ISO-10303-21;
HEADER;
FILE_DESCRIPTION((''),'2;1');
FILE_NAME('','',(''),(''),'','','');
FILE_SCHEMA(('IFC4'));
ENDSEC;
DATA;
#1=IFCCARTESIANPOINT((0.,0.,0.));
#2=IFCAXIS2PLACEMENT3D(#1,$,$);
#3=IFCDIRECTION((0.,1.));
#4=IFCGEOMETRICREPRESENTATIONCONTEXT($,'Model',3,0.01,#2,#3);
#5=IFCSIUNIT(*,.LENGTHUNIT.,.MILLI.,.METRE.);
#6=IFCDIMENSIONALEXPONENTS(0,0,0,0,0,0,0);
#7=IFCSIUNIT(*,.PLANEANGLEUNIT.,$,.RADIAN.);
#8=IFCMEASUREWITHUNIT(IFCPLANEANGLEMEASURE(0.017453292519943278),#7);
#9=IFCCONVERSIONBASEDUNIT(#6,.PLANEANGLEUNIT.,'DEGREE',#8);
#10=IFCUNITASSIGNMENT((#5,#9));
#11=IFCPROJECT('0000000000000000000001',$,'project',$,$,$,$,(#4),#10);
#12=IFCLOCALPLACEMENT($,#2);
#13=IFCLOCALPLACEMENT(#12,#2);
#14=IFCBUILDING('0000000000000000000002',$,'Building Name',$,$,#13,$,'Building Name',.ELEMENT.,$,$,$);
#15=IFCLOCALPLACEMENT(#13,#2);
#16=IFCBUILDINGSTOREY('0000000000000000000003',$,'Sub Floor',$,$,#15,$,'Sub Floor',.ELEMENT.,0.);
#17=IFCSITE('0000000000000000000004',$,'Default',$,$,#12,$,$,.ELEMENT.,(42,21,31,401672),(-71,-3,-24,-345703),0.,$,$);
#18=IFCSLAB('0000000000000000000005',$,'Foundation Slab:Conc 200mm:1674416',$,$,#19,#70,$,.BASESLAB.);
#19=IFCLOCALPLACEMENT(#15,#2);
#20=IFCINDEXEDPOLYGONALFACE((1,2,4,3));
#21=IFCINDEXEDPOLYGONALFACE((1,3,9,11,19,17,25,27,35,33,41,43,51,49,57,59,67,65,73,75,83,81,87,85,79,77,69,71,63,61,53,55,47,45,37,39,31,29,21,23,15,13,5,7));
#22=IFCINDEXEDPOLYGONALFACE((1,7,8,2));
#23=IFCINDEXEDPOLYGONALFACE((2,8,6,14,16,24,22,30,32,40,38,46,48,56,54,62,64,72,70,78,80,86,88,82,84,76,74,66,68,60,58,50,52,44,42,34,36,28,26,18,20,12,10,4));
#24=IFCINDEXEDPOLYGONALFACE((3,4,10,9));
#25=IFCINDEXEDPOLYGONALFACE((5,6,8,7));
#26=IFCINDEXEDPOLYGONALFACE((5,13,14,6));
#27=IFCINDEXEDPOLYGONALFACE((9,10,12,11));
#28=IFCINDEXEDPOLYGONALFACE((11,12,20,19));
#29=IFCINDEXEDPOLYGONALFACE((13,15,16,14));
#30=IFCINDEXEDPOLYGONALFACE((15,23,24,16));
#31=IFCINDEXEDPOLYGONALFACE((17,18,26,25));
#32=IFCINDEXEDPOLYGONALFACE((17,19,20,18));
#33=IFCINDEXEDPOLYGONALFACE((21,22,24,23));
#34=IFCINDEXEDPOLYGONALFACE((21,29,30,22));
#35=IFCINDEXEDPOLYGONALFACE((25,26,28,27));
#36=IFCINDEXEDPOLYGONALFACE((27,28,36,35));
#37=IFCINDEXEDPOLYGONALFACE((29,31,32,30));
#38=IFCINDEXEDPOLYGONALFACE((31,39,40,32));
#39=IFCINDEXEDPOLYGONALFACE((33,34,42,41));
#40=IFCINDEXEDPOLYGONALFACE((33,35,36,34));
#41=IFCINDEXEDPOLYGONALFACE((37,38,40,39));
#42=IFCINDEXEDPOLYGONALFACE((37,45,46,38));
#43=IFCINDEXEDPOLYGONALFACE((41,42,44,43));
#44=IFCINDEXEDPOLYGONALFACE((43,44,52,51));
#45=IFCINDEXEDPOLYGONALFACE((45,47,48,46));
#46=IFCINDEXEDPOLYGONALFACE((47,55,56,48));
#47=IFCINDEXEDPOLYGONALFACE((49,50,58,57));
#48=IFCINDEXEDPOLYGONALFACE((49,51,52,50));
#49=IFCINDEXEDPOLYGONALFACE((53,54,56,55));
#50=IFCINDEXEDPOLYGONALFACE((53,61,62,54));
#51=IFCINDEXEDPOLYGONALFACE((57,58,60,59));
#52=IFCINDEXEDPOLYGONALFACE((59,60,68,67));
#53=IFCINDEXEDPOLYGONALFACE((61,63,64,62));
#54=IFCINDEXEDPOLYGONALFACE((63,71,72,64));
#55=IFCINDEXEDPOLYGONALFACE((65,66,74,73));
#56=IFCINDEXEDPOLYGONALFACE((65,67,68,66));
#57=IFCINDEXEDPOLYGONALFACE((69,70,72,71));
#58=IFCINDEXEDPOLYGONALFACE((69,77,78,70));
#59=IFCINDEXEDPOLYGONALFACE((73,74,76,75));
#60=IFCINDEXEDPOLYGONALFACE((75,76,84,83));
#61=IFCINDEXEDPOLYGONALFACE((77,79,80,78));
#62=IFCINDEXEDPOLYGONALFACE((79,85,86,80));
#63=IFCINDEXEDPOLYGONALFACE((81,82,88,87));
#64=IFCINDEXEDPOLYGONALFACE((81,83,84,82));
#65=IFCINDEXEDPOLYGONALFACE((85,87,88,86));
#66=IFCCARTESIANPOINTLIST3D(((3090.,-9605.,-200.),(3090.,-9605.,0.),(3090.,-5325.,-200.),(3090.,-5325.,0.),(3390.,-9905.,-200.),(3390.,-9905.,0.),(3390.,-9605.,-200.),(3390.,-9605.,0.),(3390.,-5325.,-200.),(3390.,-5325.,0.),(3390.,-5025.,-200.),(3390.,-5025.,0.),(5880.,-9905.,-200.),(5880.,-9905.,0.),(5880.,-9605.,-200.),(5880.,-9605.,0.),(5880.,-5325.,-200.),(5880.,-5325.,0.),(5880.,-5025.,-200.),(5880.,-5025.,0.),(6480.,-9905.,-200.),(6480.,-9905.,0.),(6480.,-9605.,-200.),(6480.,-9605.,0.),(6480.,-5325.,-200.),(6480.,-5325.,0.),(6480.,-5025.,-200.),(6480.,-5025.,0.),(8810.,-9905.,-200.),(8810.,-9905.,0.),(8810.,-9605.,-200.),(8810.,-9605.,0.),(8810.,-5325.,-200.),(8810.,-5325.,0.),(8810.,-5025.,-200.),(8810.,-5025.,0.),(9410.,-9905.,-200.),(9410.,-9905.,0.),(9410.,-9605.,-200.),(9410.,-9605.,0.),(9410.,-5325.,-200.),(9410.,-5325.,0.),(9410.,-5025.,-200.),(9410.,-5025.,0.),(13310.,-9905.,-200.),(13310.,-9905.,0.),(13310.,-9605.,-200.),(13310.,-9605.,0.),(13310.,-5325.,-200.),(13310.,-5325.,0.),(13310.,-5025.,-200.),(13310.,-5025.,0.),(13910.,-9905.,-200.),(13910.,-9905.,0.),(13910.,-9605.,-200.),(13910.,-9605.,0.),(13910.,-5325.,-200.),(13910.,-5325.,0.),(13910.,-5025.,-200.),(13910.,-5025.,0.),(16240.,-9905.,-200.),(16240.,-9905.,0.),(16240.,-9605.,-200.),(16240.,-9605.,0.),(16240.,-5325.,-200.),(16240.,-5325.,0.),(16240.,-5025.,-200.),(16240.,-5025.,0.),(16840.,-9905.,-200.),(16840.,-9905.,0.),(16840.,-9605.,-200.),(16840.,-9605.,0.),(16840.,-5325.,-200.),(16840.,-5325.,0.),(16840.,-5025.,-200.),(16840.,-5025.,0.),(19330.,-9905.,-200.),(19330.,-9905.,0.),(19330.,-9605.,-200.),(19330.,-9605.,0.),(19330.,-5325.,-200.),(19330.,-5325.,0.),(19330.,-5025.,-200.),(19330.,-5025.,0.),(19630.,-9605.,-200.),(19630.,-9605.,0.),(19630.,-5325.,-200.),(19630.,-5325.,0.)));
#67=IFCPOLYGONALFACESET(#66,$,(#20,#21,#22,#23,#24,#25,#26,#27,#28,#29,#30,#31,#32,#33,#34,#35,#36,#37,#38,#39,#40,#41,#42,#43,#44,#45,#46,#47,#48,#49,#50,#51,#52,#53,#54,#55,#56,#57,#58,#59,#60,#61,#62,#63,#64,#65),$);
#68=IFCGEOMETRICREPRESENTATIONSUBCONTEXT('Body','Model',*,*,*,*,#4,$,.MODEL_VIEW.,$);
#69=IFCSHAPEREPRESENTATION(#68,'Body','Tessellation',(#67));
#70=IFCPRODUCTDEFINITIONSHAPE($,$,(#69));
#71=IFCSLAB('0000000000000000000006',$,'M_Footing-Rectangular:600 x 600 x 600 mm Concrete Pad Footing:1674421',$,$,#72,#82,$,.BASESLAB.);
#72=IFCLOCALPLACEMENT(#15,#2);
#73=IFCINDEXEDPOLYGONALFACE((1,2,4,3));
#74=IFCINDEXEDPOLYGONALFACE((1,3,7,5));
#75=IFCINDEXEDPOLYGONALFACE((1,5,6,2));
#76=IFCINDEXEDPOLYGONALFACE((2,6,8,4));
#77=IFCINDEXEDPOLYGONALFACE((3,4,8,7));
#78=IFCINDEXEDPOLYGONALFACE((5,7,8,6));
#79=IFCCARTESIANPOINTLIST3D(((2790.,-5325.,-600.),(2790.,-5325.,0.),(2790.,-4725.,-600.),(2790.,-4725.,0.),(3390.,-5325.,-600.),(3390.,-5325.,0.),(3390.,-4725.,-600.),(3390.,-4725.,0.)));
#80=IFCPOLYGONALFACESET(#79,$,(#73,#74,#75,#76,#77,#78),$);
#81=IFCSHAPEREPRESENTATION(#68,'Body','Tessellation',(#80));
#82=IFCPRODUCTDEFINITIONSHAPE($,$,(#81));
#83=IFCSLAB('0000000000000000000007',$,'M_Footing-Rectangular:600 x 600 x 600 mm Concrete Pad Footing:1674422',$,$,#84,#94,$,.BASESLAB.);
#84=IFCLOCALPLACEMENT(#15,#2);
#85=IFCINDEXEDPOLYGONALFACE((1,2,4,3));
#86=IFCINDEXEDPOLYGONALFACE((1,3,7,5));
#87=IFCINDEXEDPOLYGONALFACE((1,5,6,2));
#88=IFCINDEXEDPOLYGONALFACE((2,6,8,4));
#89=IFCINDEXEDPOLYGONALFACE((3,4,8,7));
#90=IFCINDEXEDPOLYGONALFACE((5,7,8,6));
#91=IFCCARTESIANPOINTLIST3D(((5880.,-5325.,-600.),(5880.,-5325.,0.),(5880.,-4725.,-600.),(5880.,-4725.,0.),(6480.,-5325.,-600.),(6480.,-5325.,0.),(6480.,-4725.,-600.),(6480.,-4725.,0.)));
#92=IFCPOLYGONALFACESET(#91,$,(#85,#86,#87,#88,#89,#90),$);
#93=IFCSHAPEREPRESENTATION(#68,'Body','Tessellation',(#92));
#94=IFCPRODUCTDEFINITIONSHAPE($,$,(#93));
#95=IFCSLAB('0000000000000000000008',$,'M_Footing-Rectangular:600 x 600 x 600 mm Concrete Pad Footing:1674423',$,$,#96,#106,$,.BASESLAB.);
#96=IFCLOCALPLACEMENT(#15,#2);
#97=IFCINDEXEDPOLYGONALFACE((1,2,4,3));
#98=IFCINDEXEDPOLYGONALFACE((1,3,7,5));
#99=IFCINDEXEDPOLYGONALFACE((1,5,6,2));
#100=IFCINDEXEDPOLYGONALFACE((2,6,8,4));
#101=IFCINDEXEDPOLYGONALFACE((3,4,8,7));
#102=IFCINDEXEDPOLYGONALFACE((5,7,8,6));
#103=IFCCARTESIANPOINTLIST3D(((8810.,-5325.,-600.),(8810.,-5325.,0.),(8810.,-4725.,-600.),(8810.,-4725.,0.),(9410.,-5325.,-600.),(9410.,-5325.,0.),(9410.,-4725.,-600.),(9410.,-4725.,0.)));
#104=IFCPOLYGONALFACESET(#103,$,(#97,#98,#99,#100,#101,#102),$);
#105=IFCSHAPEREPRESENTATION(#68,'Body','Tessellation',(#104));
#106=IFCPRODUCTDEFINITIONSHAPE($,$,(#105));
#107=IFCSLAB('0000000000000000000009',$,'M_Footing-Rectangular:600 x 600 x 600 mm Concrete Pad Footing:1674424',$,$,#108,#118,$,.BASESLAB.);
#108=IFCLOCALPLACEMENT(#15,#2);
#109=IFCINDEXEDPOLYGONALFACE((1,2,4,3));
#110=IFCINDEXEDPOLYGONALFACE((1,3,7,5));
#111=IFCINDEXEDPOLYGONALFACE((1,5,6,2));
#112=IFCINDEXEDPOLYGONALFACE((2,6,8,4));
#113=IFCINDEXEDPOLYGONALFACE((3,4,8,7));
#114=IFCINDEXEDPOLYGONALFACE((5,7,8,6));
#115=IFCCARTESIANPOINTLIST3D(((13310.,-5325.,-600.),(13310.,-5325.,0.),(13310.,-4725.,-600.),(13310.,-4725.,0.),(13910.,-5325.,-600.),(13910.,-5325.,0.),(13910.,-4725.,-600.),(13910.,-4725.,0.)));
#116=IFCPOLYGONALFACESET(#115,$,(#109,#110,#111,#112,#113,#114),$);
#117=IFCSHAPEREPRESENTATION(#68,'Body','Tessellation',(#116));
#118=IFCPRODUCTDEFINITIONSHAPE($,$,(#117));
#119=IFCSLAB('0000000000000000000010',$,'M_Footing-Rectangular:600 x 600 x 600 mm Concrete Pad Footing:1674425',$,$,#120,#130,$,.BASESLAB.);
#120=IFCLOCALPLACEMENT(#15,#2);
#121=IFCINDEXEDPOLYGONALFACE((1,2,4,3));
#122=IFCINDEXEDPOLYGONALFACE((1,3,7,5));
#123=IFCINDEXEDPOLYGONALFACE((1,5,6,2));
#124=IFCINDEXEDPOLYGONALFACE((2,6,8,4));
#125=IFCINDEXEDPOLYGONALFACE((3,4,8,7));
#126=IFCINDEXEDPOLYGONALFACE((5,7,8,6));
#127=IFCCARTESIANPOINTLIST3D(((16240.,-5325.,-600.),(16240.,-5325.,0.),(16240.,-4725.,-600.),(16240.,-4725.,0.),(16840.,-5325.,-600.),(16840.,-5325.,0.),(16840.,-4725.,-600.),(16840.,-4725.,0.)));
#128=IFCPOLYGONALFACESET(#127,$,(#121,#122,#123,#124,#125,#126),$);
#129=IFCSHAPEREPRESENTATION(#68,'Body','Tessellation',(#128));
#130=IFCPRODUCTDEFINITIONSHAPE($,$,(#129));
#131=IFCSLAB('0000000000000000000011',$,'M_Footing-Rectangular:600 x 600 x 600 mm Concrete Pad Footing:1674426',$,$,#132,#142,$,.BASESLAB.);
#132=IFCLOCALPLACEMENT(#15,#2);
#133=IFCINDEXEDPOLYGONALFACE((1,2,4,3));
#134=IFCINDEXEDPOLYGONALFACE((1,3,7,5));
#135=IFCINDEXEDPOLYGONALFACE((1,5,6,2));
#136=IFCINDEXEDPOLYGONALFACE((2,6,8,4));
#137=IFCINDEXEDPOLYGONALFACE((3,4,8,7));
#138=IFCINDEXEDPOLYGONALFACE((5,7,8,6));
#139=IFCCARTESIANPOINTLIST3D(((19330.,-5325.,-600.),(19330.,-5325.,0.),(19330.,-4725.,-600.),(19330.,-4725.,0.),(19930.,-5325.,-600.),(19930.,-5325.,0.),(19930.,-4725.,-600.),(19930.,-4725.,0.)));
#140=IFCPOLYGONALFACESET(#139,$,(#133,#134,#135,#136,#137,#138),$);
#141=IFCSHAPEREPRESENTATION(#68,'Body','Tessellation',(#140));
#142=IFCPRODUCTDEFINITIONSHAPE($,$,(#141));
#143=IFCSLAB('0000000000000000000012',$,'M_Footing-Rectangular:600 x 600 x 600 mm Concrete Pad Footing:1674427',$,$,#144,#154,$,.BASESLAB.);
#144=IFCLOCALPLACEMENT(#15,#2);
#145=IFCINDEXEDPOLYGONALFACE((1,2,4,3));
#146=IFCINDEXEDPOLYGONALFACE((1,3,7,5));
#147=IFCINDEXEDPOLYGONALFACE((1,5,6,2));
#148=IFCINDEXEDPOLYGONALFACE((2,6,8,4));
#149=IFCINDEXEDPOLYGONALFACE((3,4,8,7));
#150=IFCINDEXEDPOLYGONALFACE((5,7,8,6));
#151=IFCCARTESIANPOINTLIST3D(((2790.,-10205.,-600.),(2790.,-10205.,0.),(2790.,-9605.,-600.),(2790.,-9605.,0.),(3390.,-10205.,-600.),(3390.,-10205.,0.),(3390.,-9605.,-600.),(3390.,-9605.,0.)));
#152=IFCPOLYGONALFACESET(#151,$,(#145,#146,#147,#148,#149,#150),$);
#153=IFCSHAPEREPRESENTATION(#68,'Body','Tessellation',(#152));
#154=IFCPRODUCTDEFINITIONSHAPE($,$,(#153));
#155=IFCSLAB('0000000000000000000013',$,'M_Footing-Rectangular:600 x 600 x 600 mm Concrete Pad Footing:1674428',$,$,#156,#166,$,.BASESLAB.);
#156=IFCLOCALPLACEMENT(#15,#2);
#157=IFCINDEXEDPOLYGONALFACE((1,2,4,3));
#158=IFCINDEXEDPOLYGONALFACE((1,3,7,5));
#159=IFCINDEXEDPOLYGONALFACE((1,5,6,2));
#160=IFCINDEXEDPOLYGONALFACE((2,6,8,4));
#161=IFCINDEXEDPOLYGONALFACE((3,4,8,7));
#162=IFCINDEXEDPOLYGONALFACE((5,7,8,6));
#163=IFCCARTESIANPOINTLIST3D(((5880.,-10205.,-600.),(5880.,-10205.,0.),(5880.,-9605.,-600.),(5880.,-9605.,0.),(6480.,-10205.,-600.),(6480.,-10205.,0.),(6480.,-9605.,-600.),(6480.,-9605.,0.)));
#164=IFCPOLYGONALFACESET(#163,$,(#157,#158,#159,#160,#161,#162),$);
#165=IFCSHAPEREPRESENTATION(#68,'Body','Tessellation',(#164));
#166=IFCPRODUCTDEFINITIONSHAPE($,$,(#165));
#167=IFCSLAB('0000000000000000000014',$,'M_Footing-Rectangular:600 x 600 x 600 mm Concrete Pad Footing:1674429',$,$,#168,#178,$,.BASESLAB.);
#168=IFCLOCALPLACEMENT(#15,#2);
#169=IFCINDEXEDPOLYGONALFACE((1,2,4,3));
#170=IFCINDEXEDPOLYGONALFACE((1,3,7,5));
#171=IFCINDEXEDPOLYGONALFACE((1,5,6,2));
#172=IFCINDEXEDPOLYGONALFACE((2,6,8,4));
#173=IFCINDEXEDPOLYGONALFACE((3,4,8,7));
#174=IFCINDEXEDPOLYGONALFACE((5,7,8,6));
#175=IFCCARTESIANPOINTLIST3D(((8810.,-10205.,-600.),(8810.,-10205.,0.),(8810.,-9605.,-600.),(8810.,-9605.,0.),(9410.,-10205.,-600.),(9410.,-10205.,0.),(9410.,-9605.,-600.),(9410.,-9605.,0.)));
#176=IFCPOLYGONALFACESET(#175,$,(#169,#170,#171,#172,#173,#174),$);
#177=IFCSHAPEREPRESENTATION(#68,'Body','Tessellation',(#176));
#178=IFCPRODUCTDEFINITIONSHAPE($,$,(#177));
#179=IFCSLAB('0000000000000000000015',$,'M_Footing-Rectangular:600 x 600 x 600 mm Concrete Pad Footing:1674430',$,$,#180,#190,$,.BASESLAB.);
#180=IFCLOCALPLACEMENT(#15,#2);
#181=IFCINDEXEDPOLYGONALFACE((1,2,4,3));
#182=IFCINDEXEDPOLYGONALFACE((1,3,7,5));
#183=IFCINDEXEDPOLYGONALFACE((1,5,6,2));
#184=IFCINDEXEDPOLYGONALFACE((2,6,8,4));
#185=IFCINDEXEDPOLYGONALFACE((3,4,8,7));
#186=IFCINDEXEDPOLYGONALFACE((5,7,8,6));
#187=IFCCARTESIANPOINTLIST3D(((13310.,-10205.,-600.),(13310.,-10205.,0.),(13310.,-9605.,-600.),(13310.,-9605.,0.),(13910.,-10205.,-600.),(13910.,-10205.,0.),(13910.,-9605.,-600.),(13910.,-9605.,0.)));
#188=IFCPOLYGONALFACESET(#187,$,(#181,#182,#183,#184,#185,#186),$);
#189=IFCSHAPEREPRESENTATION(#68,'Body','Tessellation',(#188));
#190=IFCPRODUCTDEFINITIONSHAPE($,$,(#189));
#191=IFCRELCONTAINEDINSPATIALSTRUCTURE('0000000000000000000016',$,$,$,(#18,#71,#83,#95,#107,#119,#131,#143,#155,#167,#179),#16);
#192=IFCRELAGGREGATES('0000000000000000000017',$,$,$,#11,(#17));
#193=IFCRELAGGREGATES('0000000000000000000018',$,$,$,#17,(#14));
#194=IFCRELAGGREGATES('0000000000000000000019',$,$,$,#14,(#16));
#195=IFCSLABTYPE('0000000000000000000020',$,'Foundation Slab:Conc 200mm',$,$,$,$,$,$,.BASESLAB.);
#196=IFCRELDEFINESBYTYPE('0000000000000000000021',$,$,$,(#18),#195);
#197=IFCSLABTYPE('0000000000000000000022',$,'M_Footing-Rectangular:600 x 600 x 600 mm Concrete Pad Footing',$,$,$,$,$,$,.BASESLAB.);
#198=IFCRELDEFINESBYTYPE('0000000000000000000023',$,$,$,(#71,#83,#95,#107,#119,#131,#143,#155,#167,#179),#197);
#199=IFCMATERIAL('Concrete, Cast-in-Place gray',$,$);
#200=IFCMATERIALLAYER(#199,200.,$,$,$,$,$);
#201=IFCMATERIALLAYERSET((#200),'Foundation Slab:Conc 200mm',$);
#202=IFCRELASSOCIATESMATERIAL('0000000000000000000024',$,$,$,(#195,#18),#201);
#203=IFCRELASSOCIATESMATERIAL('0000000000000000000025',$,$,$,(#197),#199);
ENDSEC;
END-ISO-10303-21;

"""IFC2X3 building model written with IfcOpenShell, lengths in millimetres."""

from ifc_helpers import new_model, entity, si_unit, converted_unit, direction, frame, frame_2d, origin, origin_2d_with_axis, place, context, subcontext, project, spatial, polyline, rectangle, outline, extrude, material, layer, layer_set, layer_usage, type_object, element, save


model = new_model("IFC2X3")

# Units and contexts
model_context = context("Model", 3, precision=0.01, world=origin(), true_north=direction((0.0, 1.0)))
body_context = subcontext(model_context, "Body", "Model", "MODEL_VIEW")
ifc_project = project(units=[si_unit("LENGTHUNIT", "METRE", prefix="MILLI"), converted_unit("PLANEANGLEUNIT", "DEGREE", entity("IfcPlaneAngleMeasure", 0.017453292519943278), si_unit("PLANEANGLEUNIT", "RADIAN"), dimensions=[0, 0, 0, 0, 0, 0, 0])], contexts=[model_context])

# Site, building, storey
site_placement = place(None, origin())
site = spatial("IfcSite", under=ifc_project, at=site_placement, Name="Default", CompositionType="ELEMENT", RefLatitude=(42, 21, 31, 401672), RefLongitude=(-71, -3, -24, -345703), RefElevation=0.0)
building_placement = place(site_placement, origin())
building = spatial("IfcBuilding", under=site, at=building_placement, Name="Building Name", LongName="Building Name", CompositionType="ELEMENT")
storey_placement = place(building_placement, origin())
storey = spatial("IfcBuildingStorey", under=building, at=storey_placement, Name="Sub Floor", LongName="Sub Floor", CompositionType="ELEMENT", Elevation=0.0)

# Slabs
ifc_material_1 = material(Name="Concrete, Cast-in-Place gray")
ifc_layer = layer(ifc_material_1, 200.0)
ifc_layer_set = layer_set([ifc_layer], Name="Foundation Slab:Conc 200mm")
ifc_layer_usage = layer_usage(ifc_layer_set, "AXIS3", "POSITIVE", 0.0)
slab_type_1 = type_object("IfcSlabType", Name="Foundation Slab:Conc 200mm", PredefinedType="BASESLAB", material=ifc_layer_set)
slab_1_placement = place(storey_placement, origin())
element("IfcSlab", 1, at=slab_1_placement, inside=storey, type_object=slab_type_1, material=ifc_layer_usage, Name="Foundation Slab:Conc 200mm:1674416", PredefinedType="BASESLAB", context=body_context, shape_type="SweptSolid", body=[
    extrude(outline(polyline([(-2140.0, -8270.0), (2140.0, -8270.0), (2140.0, -7970.0), (2440.0, -7970.0), (2440.0, -5480.0), (2140.0, -5480.0), (2140.0, -4880.0), (2440.0, -4880.0), (2440.0, -2550.0), (2140.0, -2550.0), (2140.0, -1950.0), (2440.0, -1950.0), (2440.0, 1950.0), (2140.0, 1950.0), (2140.0, 2550.0), (2440.0, 2550.0), (2440.0, 4880.0), (2140.0, 4880.0), (2140.0, 5480.0), (2440.0, 5480.0), (2440.0, 7970.0), (2140.0, 7970.0), (2140.0, 8270.0), (-2140.0, 8270.0), (-2140.0, 7970.0), (-2440.0, 7970.0), (-2440.0, 5480.0), (-2140.0, 5480.0), (-2140.0, 4880.0), (-2440.0, 4880.0), (-2440.0, 2550.0), (-2140.0, 2550.0), (-2140.0, 1950.0), (-2440.0, 1950.0), (-2440.0, -1950.0), (-2140.0, -1950.0), (-2140.0, -2550.0), (-2440.0, -2550.0), (-2440.0, -4880.0), (-2140.0, -4880.0), (-2140.0, -5480.0), (-2440.0, -5480.0), (-2440.0, -7970.0), (-2140.0, -7970.0), (-2140.0, -8270.0)])), frame((11360.0, -7465.0, 0.0), z_axis=(0.0, 0.0, -1.0), x_axis=(0.0, 1.0, 0.0)), (0.0, 0.0, 1.0), 200.0),
])
slab_type_2 = type_object("IfcSlabType", Name="M_Footing-Rectangular:600 x 600 x 600 mm Concrete Pad Footing", PredefinedType="BASESLAB", material=ifc_material_1)
slab_2_placement = place(storey_placement, origin())
element("IfcSlab", 2, at=slab_2_placement, inside=storey, type_object=slab_type_2, Name="M_Footing-Rectangular:600 x 600 x 600 mm Concrete Pad Footing:1674421", PredefinedType="BASESLAB", context=body_context, shape_type="SweptSolid", body=[
    extrude(rectangle(XDim=600.0, YDim=600.0, at=origin_2d_with_axis()), frame((3090.0, -5025.0, -600.0), z_axis=(0.0, 0.0, 1.0), x_axis=(-1.0, 0.0, 0.0)), (0.0, 0.0, 1.0), 600.0),
])
slab_3_placement = place(storey_placement, origin())
element("IfcSlab", 3, at=slab_3_placement, inside=storey, type_object=slab_type_2, Name="M_Footing-Rectangular:600 x 600 x 600 mm Concrete Pad Footing:1674422", PredefinedType="BASESLAB", context=body_context, shape_type="SweptSolid", body=[
    extrude(rectangle(XDim=600.0, YDim=600.0, at=origin_2d_with_axis()), frame((6180.0, -5025.0, -600.0), z_axis=(0.0, 0.0, 1.0), x_axis=(-1.0, 0.0, 0.0)), (0.0, 0.0, 1.0), 600.0),
])
slab_4_placement = place(storey_placement, origin())
element("IfcSlab", 4, at=slab_4_placement, inside=storey, type_object=slab_type_2, Name="M_Footing-Rectangular:600 x 600 x 600 mm Concrete Pad Footing:1674423", PredefinedType="BASESLAB", context=body_context, shape_type="SweptSolid", body=[
    extrude(rectangle(XDim=600.0, YDim=600.0, at=origin_2d_with_axis()), frame((9110.0, -5025.0, -600.0), z_axis=(0.0, 0.0, 1.0), x_axis=(-1.0, 0.0, 0.0)), (0.0, 0.0, 1.0), 600.0),
])
slab_5_placement = place(storey_placement, origin())
element("IfcSlab", 5, at=slab_5_placement, inside=storey, type_object=slab_type_2, Name="M_Footing-Rectangular:600 x 600 x 600 mm Concrete Pad Footing:1674424", PredefinedType="BASESLAB", context=body_context, shape_type="SweptSolid", body=[
    extrude(rectangle(XDim=600.0, YDim=600.0, at=frame_2d((0.0, 0.0), x_axis=(1.0, 0.0))), frame((13610.0, -5025.0, -600.0), z_axis=(0.0, 0.0, 1.0), x_axis=(-1.0, 0.0, 0.0)), (0.0, 0.0, 1.0), 600.0),
])
slab_6_placement = place(storey_placement, origin())
element("IfcSlab", 6, at=slab_6_placement, inside=storey, type_object=slab_type_2, Name="M_Footing-Rectangular:600 x 600 x 600 mm Concrete Pad Footing:1674425", PredefinedType="BASESLAB", context=body_context, shape_type="SweptSolid", body=[
    extrude(rectangle(XDim=600.0, YDim=600.0, at=frame_2d((0.0, 0.0), x_axis=(1.0, 0.0))), frame((16540.0, -5025.0, -600.0), z_axis=(0.0, 0.0, 1.0), x_axis=(-1.0, 0.0, 0.0)), (0.0, 0.0, 1.0), 600.0),
])
slab_7_placement = place(storey_placement, origin())
element("IfcSlab", 7, at=slab_7_placement, inside=storey, type_object=slab_type_2, Name="M_Footing-Rectangular:600 x 600 x 600 mm Concrete Pad Footing:1674426", PredefinedType="BASESLAB", context=body_context, shape_type="SweptSolid", body=[
    extrude(rectangle(XDim=600.0, YDim=600.0, at=frame_2d((0.0, 0.0), x_axis=(1.0, 0.0))), frame((19630.0, -5025.0, -600.0), z_axis=(0.0, 0.0, 1.0), x_axis=(-1.0, 0.0, 0.0)), (0.0, 0.0, 1.0), 600.0),
])
slab_8_placement = place(storey_placement, origin())
element("IfcSlab", 8, at=slab_8_placement, inside=storey, type_object=slab_type_2, Name="M_Footing-Rectangular:600 x 600 x 600 mm Concrete Pad Footing:1674427", PredefinedType="BASESLAB", context=body_context, shape_type="SweptSolid", body=[
    extrude(rectangle(XDim=600.0, YDim=600.0, at=frame_2d((0.0, 0.0), x_axis=(1.0, 0.0))), frame((3090.0, -9905.0, -600.0), z_axis=(0.0, 0.0, 1.0), x_axis=(-1.0, 0.0, 0.0)), (0.0, 0.0, 1.0), 600.0),
])
slab_9_placement = place(storey_placement, origin())
element("IfcSlab", 9, at=slab_9_placement, inside=storey, type_object=slab_type_2, Name="M_Footing-Rectangular:600 x 600 x 600 mm Concrete Pad Footing:1674428", PredefinedType="BASESLAB", context=body_context, shape_type="SweptSolid", body=[
    extrude(rectangle(XDim=600.0, YDim=600.0, at=frame_2d((0.0, 0.0), x_axis=(1.0, 0.0))), frame((6180.0, -9905.0, -600.0), z_axis=(0.0, 0.0, 1.0), x_axis=(-1.0, 0.0, 0.0)), (0.0, 0.0, 1.0), 600.0),
])
slab_10_placement = place(storey_placement, origin())
element("IfcSlab", 10, at=slab_10_placement, inside=storey, type_object=slab_type_2, Name="M_Footing-Rectangular:600 x 600 x 600 mm Concrete Pad Footing:1674429", PredefinedType="BASESLAB", context=body_context, shape_type="SweptSolid", body=[
    extrude(rectangle(XDim=600.0, YDim=600.0, at=frame_2d((0.0, 0.0), x_axis=(1.0, 0.0))), frame((9110.0, -9905.0, -600.0), z_axis=(0.0, 0.0, 1.0), x_axis=(-1.0, 0.0, 0.0)), (0.0, 0.0, 1.0), 600.0),
])
slab_11_placement = place(storey_placement, origin())
element("IfcSlab", 11, at=slab_11_placement, inside=storey, type_object=slab_type_2, Name="M_Footing-Rectangular:600 x 600 x 600 mm Concrete Pad Footing:1674430", PredefinedType="BASESLAB", context=body_context, shape_type="SweptSolid", body=[
    extrude(rectangle(XDim=600.0, YDim=600.0, at=frame_2d((0.0, 0.0), x_axis=(1.0, 0.0))), frame((13610.0, -9905.0, -600.0), z_axis=(0.0, 0.0, 1.0), x_axis=(-1.0, 0.0, 0.0)), (0.0, 0.0, 1.0), 600.0),
])

save(model, "model.ifc")
